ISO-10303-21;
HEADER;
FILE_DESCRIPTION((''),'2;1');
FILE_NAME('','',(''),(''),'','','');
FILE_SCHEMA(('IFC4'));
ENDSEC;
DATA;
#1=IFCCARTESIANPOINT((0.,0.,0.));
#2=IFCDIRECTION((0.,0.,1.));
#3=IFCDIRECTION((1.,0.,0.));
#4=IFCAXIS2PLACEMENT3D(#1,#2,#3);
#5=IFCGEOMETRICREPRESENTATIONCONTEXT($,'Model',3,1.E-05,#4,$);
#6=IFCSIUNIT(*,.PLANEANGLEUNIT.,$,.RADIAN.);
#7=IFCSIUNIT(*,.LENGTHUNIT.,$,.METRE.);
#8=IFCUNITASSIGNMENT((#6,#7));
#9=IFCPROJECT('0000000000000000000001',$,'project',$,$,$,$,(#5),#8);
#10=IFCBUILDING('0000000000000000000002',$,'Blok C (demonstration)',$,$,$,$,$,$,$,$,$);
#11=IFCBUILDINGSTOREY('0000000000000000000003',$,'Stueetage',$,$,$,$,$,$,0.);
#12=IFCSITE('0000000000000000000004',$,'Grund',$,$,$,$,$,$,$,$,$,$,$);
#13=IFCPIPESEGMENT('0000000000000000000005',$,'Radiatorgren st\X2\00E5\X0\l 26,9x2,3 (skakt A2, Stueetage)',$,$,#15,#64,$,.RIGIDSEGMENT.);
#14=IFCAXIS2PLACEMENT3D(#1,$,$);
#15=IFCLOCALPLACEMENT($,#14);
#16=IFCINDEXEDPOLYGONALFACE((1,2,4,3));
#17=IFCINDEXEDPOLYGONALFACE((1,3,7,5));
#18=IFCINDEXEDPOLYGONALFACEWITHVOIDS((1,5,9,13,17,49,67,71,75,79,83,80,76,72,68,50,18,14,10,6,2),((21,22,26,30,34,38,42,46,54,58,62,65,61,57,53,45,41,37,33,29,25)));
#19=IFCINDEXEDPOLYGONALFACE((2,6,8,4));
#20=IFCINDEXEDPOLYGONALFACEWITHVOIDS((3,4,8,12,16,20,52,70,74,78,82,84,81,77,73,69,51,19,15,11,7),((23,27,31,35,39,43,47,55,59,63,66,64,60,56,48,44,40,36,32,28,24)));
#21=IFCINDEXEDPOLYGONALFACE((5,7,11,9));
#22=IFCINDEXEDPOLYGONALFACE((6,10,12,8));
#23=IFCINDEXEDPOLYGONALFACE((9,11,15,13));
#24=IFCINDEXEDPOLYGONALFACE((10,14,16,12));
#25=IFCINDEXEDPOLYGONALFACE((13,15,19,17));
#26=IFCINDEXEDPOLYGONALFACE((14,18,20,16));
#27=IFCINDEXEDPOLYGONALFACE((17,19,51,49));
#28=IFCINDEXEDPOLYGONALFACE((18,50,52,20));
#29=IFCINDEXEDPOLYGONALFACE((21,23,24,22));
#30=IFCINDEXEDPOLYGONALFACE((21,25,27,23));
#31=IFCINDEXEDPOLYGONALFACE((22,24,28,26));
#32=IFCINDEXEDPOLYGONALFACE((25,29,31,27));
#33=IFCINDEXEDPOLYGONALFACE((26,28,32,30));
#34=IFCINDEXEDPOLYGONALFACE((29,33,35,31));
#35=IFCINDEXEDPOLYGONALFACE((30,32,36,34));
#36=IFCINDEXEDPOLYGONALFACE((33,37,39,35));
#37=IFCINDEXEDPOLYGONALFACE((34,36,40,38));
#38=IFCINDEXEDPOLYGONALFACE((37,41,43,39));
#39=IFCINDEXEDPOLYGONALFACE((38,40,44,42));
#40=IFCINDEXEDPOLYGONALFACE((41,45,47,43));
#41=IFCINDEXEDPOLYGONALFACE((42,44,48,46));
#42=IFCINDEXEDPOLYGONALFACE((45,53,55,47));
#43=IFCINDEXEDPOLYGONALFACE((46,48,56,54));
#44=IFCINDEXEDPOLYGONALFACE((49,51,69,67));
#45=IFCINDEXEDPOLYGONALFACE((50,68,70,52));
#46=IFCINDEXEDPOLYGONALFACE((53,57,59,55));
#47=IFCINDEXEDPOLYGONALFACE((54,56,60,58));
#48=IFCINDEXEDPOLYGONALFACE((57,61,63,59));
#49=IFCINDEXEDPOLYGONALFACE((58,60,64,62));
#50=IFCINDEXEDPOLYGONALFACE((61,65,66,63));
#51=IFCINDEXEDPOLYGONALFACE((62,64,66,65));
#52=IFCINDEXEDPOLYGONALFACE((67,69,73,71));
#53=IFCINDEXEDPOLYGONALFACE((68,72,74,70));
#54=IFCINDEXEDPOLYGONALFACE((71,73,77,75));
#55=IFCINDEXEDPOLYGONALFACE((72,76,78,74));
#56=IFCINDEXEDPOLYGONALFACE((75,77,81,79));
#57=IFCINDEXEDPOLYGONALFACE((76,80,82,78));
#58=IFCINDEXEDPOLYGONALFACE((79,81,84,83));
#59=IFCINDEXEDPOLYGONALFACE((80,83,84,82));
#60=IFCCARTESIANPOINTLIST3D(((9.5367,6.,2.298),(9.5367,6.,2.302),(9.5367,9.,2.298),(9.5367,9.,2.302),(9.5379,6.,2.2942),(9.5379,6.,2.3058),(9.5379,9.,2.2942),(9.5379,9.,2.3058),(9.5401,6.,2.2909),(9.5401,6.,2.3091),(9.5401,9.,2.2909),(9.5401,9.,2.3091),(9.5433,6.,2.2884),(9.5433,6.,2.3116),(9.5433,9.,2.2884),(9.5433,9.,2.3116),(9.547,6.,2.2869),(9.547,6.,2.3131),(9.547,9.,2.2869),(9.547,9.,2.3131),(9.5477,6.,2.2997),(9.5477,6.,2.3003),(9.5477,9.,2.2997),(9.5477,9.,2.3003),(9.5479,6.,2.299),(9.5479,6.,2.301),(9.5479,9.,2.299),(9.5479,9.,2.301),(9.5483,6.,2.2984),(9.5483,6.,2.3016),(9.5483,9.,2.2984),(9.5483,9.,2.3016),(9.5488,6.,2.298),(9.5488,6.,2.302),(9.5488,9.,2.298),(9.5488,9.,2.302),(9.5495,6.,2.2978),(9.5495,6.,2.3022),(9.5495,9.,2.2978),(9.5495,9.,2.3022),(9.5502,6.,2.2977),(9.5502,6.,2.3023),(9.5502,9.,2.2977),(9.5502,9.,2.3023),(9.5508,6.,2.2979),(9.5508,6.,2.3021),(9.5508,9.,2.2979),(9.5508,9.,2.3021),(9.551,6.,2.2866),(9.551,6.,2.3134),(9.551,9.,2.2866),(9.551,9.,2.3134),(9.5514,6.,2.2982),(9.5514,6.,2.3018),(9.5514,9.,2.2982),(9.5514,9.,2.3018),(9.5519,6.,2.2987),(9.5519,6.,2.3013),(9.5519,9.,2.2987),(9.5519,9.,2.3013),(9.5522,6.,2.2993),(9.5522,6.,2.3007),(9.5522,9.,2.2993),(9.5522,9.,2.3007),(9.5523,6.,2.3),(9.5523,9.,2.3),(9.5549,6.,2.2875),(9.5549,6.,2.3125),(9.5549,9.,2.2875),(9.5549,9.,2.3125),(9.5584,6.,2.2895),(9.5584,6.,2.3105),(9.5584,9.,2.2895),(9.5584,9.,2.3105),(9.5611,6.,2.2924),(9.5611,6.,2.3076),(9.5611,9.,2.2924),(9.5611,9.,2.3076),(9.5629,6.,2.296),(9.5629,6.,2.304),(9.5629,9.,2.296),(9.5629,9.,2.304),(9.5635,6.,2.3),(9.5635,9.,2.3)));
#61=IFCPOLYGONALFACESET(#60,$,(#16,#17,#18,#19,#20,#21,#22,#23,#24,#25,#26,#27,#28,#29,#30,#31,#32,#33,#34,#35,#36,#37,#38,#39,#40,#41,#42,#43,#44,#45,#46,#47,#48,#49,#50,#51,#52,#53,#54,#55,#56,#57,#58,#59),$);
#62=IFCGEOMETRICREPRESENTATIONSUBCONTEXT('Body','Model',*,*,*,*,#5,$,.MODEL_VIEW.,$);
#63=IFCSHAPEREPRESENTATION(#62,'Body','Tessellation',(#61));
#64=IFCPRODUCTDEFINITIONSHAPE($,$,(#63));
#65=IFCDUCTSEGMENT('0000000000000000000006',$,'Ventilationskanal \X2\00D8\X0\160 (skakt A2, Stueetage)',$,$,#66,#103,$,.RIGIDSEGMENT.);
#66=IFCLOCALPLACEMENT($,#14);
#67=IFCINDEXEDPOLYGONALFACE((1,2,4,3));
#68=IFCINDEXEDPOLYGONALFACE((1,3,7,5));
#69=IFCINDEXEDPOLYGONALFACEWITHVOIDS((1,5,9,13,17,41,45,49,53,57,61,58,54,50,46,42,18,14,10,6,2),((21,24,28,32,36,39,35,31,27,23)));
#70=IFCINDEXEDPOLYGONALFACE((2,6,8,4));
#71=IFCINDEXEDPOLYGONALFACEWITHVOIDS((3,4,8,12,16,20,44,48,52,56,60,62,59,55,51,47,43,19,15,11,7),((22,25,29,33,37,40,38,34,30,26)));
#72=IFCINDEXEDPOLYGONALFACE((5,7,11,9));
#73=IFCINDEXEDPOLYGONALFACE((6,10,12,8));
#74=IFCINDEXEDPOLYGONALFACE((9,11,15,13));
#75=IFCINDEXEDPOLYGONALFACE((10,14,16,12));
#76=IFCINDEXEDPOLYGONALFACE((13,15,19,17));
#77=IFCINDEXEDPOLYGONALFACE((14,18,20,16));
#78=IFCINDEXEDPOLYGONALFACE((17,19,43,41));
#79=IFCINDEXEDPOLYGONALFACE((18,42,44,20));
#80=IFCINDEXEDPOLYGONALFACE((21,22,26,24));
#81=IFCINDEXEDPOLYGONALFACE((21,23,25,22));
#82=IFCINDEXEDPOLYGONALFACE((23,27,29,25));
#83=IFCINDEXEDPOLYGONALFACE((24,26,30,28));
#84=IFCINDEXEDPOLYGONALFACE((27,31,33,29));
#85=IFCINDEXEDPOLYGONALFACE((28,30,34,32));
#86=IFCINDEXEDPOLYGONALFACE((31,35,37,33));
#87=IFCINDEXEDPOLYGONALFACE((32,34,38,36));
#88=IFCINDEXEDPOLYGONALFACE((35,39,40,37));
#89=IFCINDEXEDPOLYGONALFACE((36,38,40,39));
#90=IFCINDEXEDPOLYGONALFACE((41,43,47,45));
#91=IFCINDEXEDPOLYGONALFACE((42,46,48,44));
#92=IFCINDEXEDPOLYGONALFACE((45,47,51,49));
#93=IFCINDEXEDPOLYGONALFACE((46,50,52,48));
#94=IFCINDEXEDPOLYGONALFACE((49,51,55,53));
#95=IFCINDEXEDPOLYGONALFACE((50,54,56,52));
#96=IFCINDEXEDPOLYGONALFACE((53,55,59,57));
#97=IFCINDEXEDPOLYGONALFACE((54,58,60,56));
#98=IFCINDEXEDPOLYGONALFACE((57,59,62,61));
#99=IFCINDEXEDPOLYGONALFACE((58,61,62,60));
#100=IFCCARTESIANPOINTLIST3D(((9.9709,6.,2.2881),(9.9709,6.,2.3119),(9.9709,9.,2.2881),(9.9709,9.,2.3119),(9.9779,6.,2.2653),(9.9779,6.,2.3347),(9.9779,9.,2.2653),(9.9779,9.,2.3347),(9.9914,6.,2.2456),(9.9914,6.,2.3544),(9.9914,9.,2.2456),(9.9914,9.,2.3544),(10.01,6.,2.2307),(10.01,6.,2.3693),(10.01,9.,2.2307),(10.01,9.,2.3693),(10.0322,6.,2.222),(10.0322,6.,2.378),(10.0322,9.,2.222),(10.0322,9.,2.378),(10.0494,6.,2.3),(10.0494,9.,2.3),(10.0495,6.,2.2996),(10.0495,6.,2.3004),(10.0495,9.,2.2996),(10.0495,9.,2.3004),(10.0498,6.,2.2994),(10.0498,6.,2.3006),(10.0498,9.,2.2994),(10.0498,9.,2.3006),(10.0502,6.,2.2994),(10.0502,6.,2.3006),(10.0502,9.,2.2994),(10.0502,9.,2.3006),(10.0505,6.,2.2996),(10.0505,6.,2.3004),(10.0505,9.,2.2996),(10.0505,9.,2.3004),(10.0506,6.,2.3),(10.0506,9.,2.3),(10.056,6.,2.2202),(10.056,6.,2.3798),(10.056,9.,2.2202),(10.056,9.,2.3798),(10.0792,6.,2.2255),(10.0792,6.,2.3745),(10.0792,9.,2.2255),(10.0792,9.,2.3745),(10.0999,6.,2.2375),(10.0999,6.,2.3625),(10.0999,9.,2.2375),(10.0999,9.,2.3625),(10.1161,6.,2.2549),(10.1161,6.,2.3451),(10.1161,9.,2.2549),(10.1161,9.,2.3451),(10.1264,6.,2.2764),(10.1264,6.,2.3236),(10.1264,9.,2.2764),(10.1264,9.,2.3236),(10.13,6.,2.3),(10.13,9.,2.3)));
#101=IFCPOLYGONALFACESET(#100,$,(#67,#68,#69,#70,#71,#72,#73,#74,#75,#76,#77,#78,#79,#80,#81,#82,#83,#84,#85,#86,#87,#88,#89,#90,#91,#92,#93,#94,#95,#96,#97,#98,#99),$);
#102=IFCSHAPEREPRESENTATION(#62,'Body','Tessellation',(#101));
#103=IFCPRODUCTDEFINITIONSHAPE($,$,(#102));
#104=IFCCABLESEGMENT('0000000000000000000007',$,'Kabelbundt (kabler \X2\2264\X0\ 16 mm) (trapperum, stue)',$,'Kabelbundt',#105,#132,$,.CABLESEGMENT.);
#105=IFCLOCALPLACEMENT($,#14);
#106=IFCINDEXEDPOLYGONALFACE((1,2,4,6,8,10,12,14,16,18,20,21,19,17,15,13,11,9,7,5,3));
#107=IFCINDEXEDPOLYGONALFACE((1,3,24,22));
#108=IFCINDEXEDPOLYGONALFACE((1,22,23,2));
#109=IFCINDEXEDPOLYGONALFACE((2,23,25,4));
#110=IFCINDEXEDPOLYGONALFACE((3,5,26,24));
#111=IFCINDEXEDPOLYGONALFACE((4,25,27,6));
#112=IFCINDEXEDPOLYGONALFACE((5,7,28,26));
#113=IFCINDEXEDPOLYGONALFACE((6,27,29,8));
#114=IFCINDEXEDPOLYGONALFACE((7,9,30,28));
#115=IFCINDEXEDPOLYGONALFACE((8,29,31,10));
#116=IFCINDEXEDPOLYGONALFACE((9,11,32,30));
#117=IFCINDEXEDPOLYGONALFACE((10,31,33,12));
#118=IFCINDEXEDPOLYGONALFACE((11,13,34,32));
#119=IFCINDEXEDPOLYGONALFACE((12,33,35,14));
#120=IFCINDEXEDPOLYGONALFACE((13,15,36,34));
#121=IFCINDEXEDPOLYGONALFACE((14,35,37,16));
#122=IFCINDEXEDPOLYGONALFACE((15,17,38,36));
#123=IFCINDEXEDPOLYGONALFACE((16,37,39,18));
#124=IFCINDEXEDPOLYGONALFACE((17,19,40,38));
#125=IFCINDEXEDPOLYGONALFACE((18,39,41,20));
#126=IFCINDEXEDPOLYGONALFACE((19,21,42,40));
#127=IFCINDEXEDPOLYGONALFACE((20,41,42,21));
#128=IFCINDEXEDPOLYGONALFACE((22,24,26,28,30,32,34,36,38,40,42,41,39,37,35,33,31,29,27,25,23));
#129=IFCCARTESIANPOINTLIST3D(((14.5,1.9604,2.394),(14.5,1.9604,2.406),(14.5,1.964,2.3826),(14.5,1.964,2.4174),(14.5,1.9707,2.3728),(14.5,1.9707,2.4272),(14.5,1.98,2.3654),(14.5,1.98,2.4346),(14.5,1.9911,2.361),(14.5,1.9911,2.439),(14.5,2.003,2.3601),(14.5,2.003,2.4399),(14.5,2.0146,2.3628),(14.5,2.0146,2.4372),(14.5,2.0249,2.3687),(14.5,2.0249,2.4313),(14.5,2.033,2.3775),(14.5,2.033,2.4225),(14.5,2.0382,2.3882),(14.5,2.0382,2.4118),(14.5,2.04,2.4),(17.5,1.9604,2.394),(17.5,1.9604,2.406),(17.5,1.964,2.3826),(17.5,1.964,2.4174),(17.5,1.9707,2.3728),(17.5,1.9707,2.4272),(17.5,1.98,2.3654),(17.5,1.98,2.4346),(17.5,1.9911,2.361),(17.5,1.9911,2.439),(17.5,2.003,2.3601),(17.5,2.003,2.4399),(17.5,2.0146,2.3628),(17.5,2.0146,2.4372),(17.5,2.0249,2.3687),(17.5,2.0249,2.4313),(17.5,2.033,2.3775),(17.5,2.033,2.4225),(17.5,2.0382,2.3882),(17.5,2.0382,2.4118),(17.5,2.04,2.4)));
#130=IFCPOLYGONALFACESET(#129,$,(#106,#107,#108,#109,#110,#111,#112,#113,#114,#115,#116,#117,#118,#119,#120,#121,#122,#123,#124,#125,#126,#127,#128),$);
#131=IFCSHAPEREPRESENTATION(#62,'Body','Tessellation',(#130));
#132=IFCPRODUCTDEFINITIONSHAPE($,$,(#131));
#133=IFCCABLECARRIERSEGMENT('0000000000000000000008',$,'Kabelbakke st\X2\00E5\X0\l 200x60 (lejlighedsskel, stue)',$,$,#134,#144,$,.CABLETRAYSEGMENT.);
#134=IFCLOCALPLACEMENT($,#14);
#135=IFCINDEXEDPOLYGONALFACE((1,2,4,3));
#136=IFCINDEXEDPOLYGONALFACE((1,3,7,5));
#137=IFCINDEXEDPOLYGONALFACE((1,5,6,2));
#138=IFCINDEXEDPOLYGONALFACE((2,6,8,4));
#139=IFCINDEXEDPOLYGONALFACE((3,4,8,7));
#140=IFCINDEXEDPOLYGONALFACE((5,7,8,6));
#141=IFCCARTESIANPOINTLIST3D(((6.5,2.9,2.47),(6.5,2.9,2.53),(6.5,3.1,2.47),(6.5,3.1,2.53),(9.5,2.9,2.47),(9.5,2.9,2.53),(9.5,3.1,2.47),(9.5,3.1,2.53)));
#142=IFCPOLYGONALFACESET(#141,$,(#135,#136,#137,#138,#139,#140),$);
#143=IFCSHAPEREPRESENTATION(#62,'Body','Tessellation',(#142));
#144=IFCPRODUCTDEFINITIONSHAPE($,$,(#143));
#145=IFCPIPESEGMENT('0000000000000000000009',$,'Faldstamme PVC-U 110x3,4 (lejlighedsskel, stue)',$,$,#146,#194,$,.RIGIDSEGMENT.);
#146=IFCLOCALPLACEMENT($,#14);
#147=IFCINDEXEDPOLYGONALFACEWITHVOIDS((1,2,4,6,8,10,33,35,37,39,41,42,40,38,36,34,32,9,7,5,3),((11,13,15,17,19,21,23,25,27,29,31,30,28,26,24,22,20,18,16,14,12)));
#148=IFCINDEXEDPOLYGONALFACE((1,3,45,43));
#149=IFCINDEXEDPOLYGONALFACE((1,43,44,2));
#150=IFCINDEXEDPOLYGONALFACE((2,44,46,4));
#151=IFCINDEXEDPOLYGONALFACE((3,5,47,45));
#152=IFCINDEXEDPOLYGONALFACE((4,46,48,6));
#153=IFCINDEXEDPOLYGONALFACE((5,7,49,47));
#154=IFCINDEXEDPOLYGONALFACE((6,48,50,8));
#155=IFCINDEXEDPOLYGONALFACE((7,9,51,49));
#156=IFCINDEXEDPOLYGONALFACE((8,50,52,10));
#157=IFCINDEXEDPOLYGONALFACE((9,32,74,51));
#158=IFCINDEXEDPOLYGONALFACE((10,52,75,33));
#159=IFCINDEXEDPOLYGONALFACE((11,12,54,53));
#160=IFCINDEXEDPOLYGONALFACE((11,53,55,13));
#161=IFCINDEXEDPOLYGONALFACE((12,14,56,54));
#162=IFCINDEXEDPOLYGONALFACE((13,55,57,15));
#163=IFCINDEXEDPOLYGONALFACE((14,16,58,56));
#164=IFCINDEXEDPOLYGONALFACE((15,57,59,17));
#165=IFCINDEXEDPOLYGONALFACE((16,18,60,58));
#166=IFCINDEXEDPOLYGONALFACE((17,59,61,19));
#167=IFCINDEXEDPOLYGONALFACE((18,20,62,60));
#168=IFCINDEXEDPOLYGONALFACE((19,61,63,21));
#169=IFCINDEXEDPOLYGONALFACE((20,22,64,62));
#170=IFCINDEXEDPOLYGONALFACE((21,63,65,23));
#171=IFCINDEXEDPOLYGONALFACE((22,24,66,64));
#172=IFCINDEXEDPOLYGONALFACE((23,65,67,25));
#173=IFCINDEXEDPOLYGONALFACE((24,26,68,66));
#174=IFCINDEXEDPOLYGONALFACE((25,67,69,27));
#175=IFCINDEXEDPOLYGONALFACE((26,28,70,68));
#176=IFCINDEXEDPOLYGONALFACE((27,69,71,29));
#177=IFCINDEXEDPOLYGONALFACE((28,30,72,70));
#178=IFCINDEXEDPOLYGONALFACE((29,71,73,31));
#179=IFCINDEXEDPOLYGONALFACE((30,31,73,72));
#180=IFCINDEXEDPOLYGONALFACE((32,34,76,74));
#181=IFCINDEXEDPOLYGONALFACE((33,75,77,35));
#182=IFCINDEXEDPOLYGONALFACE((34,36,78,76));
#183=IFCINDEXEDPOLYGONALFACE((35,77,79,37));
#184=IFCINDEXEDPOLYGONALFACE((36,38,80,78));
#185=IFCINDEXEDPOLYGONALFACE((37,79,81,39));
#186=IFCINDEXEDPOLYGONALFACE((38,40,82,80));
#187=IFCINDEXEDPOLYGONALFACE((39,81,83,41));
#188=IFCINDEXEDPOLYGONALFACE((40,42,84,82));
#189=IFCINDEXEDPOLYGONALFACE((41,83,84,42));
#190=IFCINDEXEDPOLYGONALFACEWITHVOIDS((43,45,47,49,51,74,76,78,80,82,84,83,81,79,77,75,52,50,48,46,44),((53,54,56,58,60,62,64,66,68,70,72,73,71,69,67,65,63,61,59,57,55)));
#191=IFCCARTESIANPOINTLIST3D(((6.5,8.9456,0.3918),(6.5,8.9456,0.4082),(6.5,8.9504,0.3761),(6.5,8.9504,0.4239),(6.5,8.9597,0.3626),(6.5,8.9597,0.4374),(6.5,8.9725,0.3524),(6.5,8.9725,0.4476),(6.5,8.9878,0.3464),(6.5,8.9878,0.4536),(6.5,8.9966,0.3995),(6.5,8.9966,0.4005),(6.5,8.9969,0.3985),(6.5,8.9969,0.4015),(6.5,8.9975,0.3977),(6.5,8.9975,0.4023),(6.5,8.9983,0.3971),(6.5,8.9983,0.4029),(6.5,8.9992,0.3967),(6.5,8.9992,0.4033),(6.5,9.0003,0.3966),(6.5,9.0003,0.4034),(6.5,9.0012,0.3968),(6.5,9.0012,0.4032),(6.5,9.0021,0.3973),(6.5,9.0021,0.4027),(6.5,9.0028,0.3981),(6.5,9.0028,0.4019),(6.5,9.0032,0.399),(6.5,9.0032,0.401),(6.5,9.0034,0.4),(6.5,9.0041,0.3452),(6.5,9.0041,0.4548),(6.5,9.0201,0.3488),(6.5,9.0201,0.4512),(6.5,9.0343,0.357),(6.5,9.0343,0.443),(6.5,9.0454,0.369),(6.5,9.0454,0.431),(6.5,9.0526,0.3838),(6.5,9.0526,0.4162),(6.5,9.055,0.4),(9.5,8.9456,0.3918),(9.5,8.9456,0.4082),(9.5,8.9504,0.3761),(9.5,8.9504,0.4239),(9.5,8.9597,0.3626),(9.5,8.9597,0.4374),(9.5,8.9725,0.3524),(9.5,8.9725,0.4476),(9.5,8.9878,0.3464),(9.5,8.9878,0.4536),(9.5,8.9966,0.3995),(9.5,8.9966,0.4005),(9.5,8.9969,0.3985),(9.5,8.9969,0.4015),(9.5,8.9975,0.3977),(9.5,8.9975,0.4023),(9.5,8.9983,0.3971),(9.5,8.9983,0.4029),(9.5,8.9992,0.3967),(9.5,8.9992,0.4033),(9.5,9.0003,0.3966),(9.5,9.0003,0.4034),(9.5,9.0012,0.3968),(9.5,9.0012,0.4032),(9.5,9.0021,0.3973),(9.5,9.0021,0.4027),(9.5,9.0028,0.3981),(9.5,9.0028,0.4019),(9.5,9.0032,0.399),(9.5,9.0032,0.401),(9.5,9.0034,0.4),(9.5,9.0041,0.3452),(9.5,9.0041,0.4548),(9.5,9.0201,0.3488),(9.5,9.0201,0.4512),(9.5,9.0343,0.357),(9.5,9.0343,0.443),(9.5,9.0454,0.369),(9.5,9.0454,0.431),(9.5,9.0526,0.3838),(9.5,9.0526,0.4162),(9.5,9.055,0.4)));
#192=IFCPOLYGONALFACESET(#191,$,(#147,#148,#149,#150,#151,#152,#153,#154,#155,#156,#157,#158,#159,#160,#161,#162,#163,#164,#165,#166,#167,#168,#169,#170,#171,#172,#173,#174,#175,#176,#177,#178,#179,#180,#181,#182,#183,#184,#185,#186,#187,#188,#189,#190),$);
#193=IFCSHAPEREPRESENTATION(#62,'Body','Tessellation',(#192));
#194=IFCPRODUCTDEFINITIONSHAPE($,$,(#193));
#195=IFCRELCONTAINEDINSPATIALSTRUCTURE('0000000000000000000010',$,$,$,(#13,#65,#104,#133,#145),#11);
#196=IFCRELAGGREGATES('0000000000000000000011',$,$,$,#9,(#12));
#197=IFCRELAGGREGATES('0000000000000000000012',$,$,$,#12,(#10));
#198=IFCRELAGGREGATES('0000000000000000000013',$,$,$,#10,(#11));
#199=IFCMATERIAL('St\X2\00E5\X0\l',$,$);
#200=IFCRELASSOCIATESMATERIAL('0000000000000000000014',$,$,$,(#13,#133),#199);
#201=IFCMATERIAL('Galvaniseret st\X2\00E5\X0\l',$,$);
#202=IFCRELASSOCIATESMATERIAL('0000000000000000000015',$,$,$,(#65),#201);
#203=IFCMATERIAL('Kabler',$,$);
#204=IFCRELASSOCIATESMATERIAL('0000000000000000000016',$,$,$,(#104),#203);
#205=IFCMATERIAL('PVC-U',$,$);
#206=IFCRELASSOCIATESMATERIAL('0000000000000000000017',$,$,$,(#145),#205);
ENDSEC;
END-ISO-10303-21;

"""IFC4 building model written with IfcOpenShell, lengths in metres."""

from ifc_helpers import new_model, si_unit, frame, origin_with_axes, place, context, subcontext, project, spatial, polyline, circle, hollow_circle, outline, extrude, material, element, save


model = new_model("IFC4")

# Units and contexts
model_context = context("Model", 3, precision=1e-05, world=origin_with_axes())
body_context = subcontext(model_context, "Body", "Model", "MODEL_VIEW")
ifc_project = project(units=[si_unit("PLANEANGLEUNIT", "RADIAN"), si_unit("LENGTHUNIT", "METRE")], contexts=[model_context])

# Site, building, storey
site = spatial("IfcSite", under=ifc_project, Name="Grund")
building = spatial("IfcBuilding", under=site, Name="Blok C (demonstration)")
storey = spatial("IfcBuildingStorey", under=building, Name="Stueetage", Elevation=0.0)

# Pipe segment
ifc_material_1 = material(Name="PVC-U")
ifc_material_2 = material(Name="Stål")
pipe_segment_1_placement = place(None, origin_with_axes())
element("IfcPipeSegment", 1, at=pipe_segment_1_placement, inside=storey, material=ifc_material_2, Name="Radiatorgren stål 26,9x2,3 (skakt A2, Stueetage)", PredefinedType="RIGIDSEGMENT", context=body_context, shape_type="SweptSolid", body=[
    extrude(hollow_circle(Radius=0.0135, WallThickness=0.0112), frame((9.55, 6.0, 2.3), z_axis=(0.0, 1.0, 0.0), x_axis=(1.0, 0.0, 0.0)), (0.0, 0.0, 1.0), 3.0),
])

# Duct segment
ifc_material_3 = material(Name="Galvaniseret stål")
duct_segment_placement = place(None, origin_with_axes())
element("IfcDuctSegment", 2, at=duct_segment_placement, inside=storey, material=ifc_material_3, Name="Ventilationskanal Ø160 (skakt A2, Stueetage)", PredefinedType="RIGIDSEGMENT", context=body_context, shape_type="SweptSolid", body=[
    extrude(hollow_circle(Radius=0.08, WallThickness=0.0794), frame((10.05, 6.0, 2.3), z_axis=(0.0, 1.0, 0.0), x_axis=(1.0, 0.0, 0.0)), (0.0, 0.0, 1.0), 3.0),
])

# Cable segment
ifc_material_4 = material(Name="Kabler")
cable_segment_placement = place(None, origin_with_axes())
element("IfcCableSegment", 3, at=cable_segment_placement, inside=storey, material=ifc_material_4, Name="Kabelbundt (kabler ≤ 16 mm) (trapperum, stue)", ObjectType="Kabelbundt", PredefinedType="CABLESEGMENT", context=body_context, shape_type="SweptSolid", body=[
    extrude(circle(Radius=0.04), frame((14.5, 2.0, 2.4), z_axis=(1.0, 0.0, 0.0), x_axis=(0.0, 1.0, 0.0)), (0.0, 0.0, 1.0), 3.0),
])

# Cable carrier segment
cable_carrier_segment_placement = place(None, origin_with_axes())
element("IfcCableCarrierSegment", 4, at=cable_carrier_segment_placement, inside=storey, material=ifc_material_2, Name="Kabelbakke stål 200x60 (lejlighedsskel, stue)", PredefinedType="CABLETRAYSEGMENT", context=body_context, shape_type="SweptSolid", body=[
    extrude(outline(polyline([(6.5, 2.9), (9.5, 2.9), (9.5, 3.1), (6.5, 3.1), (6.5, 2.9)])), frame((0.0, 0.0, 2.47)), (0.0, 0.0, 1.0), 0.06),
])

# Pipe segment
pipe_segment_2_placement = place(None, origin_with_axes())
element("IfcPipeSegment", 5, at=pipe_segment_2_placement, inside=storey, material=ifc_material_1, Name="Faldstamme PVC-U 110x3,4 (lejlighedsskel, stue)", PredefinedType="RIGIDSEGMENT", context=body_context, shape_type="SweptSolid", body=[
    extrude(hollow_circle(Radius=0.055, WallThickness=0.0516), frame((6.5, 9.0, 0.4), z_axis=(1.0, 0.0, 0.0), x_axis=(0.0, 1.0, 0.0)), (0.0, 0.0, 1.0), 3.0),
])

save(model, "model.ifc")
